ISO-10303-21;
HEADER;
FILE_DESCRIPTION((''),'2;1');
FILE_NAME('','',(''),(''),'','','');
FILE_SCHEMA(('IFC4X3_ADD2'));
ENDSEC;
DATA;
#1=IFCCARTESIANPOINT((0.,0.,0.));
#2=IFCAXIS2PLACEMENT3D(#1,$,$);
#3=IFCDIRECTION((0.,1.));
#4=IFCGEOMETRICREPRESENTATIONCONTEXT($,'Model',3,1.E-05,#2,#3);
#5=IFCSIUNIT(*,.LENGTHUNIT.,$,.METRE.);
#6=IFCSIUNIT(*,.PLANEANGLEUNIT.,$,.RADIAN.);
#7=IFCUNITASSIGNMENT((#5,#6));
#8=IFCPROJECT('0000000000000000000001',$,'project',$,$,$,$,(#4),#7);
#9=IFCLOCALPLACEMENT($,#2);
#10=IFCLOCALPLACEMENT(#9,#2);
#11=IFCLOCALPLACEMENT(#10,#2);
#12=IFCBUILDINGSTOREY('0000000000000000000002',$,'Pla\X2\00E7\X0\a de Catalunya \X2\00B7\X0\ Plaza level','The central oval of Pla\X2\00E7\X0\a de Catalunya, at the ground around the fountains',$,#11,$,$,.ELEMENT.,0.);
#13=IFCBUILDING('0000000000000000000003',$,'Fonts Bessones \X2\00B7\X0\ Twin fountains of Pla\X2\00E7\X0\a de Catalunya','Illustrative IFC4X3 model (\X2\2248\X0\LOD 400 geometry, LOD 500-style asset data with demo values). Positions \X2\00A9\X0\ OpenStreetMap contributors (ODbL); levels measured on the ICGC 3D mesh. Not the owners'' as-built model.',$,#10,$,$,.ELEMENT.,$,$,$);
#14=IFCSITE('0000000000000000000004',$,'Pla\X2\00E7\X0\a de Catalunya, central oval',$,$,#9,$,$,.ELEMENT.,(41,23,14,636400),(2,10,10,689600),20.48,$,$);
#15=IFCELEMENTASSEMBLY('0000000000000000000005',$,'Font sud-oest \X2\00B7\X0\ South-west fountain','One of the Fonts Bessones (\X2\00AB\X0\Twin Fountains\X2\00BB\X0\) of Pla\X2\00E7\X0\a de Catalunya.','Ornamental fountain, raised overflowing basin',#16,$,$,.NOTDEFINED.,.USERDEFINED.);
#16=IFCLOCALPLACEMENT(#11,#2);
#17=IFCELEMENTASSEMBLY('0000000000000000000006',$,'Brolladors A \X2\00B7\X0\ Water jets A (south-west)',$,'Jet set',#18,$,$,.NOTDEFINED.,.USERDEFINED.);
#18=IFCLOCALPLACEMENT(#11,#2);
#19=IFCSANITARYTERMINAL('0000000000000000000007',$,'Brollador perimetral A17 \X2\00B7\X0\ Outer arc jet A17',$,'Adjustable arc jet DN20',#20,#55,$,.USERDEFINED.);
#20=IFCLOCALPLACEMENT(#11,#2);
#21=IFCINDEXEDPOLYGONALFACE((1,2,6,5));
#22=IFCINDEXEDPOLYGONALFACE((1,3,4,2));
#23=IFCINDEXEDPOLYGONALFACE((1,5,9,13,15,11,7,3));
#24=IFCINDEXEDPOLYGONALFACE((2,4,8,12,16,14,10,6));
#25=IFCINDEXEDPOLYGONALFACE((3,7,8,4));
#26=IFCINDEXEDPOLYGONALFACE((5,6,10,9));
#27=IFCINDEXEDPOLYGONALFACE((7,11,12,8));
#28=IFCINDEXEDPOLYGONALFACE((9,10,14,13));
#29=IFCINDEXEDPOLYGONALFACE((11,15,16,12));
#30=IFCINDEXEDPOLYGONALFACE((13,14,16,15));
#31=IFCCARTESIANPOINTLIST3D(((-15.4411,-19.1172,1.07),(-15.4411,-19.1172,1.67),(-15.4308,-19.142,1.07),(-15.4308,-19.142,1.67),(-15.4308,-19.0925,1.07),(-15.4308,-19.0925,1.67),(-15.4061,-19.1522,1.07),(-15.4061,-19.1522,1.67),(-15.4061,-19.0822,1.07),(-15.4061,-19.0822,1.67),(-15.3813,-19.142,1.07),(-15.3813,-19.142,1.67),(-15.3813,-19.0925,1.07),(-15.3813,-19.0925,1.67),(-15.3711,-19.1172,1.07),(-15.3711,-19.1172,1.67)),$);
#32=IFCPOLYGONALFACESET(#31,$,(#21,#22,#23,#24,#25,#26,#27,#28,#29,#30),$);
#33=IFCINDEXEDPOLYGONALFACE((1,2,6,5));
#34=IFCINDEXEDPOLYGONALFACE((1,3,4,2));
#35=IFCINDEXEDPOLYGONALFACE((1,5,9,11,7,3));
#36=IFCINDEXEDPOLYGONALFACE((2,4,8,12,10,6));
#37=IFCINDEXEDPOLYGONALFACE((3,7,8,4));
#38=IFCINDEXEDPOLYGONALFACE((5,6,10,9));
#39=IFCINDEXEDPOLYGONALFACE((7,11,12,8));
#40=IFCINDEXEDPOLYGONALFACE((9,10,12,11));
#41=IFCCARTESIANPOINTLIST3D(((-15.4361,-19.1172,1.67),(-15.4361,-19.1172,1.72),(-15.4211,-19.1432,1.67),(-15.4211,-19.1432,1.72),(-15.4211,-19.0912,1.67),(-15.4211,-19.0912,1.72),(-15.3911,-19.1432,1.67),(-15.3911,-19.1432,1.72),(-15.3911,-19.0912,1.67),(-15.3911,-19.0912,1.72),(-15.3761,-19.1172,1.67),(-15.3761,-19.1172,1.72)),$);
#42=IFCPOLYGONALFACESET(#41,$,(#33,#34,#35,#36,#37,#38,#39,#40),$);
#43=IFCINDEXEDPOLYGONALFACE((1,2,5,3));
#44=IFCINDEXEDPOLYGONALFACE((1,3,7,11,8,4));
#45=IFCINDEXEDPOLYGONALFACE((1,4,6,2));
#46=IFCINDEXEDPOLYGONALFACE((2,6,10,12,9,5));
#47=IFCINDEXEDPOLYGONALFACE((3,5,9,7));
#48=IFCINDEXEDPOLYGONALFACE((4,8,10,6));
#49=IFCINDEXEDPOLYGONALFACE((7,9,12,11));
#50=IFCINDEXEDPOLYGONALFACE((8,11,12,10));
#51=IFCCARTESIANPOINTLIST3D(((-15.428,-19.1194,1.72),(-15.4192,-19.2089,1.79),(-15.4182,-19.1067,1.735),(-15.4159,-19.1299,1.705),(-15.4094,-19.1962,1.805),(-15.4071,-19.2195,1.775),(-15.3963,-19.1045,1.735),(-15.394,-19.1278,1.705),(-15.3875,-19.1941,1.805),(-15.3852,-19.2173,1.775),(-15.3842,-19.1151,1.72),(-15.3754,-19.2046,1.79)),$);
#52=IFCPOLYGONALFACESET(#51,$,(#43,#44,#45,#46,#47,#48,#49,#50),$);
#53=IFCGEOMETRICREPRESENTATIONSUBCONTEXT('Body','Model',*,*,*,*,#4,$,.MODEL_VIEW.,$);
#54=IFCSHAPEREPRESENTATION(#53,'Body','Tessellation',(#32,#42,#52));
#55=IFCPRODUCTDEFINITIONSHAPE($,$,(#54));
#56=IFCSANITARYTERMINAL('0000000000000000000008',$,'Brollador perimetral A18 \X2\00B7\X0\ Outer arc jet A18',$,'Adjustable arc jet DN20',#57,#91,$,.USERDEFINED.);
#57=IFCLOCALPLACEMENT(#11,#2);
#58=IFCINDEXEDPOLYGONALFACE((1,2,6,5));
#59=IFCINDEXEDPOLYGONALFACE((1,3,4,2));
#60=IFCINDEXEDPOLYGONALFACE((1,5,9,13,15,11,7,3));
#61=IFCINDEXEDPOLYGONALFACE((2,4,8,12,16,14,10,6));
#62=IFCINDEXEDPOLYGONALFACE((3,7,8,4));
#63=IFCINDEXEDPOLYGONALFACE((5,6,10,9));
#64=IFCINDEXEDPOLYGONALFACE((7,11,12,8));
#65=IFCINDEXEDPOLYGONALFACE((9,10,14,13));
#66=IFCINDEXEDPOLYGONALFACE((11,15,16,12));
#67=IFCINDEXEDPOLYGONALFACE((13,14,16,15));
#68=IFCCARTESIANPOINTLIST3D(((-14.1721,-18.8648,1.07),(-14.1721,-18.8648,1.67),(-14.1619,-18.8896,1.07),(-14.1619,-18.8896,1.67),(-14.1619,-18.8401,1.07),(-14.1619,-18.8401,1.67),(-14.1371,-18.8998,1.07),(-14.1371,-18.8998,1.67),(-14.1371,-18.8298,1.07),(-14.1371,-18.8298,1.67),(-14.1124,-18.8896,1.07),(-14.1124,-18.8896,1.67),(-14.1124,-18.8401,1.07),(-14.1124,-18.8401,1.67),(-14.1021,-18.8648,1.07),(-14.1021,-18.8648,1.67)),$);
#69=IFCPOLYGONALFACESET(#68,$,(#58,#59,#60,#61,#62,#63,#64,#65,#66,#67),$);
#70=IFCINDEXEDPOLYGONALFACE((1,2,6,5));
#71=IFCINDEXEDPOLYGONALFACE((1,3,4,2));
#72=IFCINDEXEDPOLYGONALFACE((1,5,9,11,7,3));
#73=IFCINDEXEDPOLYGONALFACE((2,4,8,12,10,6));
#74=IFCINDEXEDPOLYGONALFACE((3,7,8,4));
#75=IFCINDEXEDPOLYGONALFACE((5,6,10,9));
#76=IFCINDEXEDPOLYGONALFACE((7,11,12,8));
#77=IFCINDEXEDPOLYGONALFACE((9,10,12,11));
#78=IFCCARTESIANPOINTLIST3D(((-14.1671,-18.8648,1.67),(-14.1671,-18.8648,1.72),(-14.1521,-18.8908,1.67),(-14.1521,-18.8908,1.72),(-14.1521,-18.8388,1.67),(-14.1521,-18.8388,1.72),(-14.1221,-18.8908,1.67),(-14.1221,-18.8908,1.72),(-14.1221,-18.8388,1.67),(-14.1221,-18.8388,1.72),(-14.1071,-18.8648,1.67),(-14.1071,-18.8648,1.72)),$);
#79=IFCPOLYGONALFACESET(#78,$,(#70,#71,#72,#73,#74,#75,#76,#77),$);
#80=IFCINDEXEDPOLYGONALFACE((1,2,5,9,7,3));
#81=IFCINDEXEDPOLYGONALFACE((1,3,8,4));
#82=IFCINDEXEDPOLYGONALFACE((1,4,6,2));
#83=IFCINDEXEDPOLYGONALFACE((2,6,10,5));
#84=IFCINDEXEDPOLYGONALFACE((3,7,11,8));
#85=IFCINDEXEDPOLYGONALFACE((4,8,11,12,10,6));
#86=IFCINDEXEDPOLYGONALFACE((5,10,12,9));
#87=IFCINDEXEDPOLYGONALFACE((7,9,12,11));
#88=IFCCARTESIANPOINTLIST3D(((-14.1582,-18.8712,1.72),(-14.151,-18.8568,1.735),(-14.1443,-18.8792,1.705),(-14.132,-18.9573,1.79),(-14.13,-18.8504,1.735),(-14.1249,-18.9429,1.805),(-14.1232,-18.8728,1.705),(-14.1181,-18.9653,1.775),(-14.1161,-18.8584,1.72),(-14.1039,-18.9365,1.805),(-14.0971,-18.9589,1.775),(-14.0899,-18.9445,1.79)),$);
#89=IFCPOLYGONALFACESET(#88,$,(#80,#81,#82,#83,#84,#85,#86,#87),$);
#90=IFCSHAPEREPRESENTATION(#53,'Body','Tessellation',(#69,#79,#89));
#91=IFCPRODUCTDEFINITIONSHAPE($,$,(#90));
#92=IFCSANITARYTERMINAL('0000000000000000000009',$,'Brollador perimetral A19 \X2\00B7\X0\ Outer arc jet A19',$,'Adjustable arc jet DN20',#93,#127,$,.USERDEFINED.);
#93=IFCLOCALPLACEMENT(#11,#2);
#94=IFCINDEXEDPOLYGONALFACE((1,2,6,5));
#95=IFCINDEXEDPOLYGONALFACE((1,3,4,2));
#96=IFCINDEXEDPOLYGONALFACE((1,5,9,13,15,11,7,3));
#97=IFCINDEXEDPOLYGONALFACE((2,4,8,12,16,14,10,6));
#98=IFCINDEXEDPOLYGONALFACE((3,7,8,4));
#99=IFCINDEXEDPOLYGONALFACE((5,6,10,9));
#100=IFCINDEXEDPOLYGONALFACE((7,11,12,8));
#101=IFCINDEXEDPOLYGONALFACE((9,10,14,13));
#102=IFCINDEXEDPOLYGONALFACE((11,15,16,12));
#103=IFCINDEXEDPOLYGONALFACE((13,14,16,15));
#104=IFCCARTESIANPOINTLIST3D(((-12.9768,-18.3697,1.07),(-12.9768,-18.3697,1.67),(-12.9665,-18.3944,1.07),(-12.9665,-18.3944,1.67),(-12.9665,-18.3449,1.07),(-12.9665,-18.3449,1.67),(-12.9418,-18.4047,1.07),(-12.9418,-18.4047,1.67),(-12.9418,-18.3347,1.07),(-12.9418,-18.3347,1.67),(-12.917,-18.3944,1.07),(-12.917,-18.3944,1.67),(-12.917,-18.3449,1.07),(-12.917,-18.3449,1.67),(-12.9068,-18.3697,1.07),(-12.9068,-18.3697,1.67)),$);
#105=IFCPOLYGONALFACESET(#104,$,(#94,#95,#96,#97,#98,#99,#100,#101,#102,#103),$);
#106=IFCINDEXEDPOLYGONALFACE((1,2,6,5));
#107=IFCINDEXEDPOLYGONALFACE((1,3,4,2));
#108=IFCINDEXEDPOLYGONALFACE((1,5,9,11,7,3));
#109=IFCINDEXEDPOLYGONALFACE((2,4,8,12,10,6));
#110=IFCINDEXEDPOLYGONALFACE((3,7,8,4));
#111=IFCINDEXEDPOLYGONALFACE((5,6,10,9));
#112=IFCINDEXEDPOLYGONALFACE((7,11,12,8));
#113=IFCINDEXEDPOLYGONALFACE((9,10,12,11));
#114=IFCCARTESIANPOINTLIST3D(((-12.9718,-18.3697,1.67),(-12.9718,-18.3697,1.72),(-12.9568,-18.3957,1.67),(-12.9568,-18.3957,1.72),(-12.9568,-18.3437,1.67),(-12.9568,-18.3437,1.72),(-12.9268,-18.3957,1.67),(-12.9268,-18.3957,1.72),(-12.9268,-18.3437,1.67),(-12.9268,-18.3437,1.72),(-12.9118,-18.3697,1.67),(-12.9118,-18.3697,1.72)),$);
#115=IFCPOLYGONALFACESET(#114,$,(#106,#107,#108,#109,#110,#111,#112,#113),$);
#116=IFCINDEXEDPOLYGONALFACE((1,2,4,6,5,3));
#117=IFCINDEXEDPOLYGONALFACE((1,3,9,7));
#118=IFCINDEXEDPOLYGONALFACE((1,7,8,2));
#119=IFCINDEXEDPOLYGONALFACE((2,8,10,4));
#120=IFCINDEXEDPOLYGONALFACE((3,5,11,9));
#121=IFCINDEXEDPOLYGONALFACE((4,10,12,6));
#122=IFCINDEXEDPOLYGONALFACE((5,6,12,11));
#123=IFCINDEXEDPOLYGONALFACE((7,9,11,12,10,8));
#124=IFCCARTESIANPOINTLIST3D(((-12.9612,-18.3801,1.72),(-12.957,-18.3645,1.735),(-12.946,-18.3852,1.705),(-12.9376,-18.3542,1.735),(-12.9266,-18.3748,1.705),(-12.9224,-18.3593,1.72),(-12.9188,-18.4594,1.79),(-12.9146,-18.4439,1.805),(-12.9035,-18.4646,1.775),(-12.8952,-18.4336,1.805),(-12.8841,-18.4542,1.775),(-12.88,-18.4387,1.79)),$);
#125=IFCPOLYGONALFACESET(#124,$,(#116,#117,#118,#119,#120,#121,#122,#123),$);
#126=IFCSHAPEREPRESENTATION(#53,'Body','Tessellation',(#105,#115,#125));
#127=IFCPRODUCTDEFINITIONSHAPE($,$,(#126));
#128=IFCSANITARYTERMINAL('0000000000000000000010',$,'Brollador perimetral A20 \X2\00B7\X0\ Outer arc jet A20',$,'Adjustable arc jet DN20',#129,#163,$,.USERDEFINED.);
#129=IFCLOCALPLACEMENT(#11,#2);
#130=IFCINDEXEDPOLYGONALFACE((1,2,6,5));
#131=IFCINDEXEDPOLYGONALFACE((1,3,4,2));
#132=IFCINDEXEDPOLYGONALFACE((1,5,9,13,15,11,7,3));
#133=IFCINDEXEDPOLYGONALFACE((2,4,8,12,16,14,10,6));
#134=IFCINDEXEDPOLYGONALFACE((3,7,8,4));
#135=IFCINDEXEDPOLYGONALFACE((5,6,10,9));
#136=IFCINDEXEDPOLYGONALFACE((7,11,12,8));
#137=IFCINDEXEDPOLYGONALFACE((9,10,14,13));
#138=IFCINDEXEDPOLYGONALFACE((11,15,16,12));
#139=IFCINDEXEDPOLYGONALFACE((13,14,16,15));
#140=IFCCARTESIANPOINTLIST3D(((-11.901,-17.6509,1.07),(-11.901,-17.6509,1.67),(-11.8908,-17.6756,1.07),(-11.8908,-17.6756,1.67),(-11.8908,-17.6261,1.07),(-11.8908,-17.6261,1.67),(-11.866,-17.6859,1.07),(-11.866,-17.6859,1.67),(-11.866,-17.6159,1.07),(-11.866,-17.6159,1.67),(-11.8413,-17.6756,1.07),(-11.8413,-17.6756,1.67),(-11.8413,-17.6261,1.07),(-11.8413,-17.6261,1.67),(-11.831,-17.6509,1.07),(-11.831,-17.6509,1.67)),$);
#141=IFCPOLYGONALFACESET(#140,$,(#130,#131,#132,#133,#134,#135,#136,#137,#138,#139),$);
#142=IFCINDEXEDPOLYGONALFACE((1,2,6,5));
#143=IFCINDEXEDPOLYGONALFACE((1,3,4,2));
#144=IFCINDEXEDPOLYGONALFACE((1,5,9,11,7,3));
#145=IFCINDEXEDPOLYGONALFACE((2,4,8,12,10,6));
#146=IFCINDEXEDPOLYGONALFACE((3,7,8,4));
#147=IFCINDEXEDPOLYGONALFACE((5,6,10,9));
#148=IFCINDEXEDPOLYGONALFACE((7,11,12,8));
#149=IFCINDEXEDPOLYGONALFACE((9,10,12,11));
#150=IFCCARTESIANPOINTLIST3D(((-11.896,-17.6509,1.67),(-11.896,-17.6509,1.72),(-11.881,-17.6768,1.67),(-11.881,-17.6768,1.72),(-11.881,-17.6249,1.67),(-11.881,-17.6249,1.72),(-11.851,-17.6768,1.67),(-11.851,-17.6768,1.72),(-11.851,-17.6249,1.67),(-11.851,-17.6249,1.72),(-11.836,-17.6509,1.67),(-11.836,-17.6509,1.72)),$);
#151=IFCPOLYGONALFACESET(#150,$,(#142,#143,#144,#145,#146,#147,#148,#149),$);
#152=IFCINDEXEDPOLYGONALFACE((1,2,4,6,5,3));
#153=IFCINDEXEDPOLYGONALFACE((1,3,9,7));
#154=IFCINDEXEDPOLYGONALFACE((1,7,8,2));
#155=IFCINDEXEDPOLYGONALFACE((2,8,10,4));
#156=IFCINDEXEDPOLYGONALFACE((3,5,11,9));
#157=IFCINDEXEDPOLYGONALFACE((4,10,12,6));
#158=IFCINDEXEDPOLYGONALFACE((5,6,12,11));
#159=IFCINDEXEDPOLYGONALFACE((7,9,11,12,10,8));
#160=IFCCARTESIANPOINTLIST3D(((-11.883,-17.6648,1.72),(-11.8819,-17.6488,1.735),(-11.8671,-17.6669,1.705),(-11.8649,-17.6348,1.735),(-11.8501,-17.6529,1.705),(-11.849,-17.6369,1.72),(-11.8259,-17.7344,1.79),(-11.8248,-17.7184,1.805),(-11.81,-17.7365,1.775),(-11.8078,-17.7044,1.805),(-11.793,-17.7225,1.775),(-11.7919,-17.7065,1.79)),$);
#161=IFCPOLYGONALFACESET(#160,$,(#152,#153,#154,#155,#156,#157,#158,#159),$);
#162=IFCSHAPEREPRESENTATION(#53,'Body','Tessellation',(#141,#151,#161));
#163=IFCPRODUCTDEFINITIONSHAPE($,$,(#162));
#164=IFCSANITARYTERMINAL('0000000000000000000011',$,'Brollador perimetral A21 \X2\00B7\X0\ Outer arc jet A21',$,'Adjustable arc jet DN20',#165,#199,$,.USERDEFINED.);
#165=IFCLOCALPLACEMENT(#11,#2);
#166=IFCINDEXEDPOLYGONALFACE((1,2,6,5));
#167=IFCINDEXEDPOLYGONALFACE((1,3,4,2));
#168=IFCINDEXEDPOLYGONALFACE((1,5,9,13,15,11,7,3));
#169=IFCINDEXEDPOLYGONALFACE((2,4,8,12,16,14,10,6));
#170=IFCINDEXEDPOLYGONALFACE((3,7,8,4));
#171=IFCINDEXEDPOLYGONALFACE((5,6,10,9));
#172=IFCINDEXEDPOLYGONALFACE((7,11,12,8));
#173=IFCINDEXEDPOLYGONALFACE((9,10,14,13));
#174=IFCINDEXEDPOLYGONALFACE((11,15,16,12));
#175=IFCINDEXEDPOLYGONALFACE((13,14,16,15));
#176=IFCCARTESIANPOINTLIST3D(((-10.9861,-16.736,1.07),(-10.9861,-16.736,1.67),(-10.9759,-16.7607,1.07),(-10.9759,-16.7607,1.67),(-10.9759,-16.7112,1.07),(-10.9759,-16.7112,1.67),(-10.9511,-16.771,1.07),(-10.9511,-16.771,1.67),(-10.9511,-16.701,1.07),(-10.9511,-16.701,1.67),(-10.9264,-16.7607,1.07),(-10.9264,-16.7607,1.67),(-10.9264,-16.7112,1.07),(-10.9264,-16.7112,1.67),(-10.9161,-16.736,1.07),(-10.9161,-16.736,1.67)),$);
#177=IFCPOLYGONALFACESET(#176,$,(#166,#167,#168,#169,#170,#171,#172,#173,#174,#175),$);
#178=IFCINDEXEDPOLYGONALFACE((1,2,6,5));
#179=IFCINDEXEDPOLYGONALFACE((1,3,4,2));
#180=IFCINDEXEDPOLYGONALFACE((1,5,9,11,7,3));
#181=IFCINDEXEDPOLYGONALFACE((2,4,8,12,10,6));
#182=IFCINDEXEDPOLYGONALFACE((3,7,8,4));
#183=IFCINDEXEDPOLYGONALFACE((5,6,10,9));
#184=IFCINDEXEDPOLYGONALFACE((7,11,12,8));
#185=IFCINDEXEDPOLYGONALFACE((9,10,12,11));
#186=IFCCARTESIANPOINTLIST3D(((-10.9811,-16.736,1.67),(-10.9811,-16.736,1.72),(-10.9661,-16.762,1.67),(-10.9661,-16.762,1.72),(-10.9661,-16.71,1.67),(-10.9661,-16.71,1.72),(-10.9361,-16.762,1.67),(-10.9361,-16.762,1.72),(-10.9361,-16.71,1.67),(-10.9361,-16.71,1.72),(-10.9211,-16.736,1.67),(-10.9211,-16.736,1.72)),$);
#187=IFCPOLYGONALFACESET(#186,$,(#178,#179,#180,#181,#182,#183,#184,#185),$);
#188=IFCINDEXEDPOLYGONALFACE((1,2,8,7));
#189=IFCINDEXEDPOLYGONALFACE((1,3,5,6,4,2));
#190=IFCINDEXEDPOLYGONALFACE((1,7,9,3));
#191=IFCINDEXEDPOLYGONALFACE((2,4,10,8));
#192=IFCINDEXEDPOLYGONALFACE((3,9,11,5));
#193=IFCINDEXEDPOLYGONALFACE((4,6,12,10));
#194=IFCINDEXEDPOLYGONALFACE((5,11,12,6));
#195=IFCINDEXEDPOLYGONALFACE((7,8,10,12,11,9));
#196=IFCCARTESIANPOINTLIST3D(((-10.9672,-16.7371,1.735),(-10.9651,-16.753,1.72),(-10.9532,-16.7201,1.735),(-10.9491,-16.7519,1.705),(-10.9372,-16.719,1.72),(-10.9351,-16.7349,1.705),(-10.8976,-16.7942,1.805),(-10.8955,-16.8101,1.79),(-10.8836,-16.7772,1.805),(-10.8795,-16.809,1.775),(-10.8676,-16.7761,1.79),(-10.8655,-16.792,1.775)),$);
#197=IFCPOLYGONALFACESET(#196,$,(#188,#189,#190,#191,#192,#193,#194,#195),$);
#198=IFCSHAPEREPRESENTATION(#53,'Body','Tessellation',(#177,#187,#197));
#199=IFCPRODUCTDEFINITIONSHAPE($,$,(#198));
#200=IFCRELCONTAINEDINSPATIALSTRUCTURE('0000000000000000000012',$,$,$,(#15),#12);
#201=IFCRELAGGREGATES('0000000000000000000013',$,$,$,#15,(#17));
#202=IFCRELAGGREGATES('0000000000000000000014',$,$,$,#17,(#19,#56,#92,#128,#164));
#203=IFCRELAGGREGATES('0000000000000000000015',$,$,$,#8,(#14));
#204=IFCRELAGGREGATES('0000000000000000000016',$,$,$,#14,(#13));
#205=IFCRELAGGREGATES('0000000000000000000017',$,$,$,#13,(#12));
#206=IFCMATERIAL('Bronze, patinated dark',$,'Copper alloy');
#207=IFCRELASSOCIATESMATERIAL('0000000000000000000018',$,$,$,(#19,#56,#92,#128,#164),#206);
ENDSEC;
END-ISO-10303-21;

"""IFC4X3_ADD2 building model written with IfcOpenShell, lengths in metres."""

from ifc_helpers import new_model, si_unit, direction, frame, origin, place, context, subcontext, project, spatial, polyline, outline, extrude, material, element, aggregate, save


model = new_model("IFC4X3_ADD2")

# Units and contexts
model_context = context("Model", 3, precision=1e-05, world=origin(), true_north=direction((0.0, 1.0)))
body_context = subcontext(model_context, "Body", "Model", "MODEL_VIEW")
ifc_project = project(units=[si_unit("LENGTHUNIT", "METRE"), si_unit("PLANEANGLEUNIT", "RADIAN")], contexts=[model_context])

# Site, building, storey
site_placement = place(None, origin())
site = spatial("IfcSite", under=ifc_project, at=site_placement, Name="Plaça de Catalunya, central oval", CompositionType="ELEMENT", RefLatitude=(41, 23, 14, 636400), RefLongitude=(2, 10, 10, 689600), RefElevation=20.48)
building_placement = place(site_placement, origin())
building = spatial("IfcBuilding", under=site, at=building_placement, Name="Fonts Bessones · Twin fountains of Plaça de Catalunya", Description="Illustrative IFC4X3 model (≈LOD 400 geometry, LOD 500-style asset data with demo values). Positions © OpenStreetMap contributors (ODbL); levels measured on the ICGC 3D mesh. Not the owners' as-built model.", CompositionType="ELEMENT")
storey_placement = place(building_placement, origin())
storey = spatial("IfcBuildingStorey", under=building, at=storey_placement, Name="Plaça de Catalunya · Plaza level", Description="The central oval of Plaça de Catalunya, at the ground around the fountains", CompositionType="ELEMENT", Elevation=0.0)

# Element assemblies, sanitary terminals
assembly_1_placement = place(building_placement, origin())
assembly_1 = element("IfcElementAssembly", 1, at=assembly_1_placement, inside=storey, Name="Font sud-oest · South-west fountain", Description="One of the Fonts Bessones («Twin Fountains») of Plaça de Catalunya.", ObjectType="Ornamental fountain, raised overflowing basin", AssemblyPlace="NOTDEFINED", PredefinedType="USERDEFINED")
assembly_2_placement = place(building_placement, origin())
assembly_2 = element("IfcElementAssembly", 2, at=assembly_2_placement, Name="Brolladors A · Water jets A (south-west)", ObjectType="Jet set", AssemblyPlace="NOTDEFINED", PredefinedType="USERDEFINED")
aggregate(assembly_1, [assembly_2])
ifc_material = material(Name="Bronze, patinated dark", Category="Copper alloy")
sanitary_terminal_1_placement = place(building_placement, origin())
sanitary_terminal_1 = element("IfcSanitaryTerminal", 3, at=sanitary_terminal_1_placement, material=ifc_material, Name="Brollador perimetral A17 · Outer arc jet A17", ObjectType="Adjustable arc jet DN20", PredefinedType="USERDEFINED", context=body_context, shape_type="SweptSolid", body=[
    extrude(outline(polyline([(-15.3711, -19.1172), (-15.3813, -19.0925), (-15.4061, -19.0822), (-15.4308, -19.0925), (-15.4411, -19.1172), (-15.4308, -19.142), (-15.4061, -19.1522), (-15.3813, -19.142), (-15.3711, -19.1172)])), frame((0.0, 0.0, 1.07)), (0.0, 0.0, 1.0), 0.6),
    extrude(outline(polyline([(-15.3761, -19.1172), (-15.3911, -19.0912), (-15.4211, -19.0912), (-15.4361, -19.1172), (-15.4211, -19.1432), (-15.3911, -19.1432), (-15.3761, -19.1172)])), frame((0.0, 0.0, 1.67)), (0.0, 0.0, 1.0), 0.05),
    extrude(outline(polyline([(0.022, 0.0), (0.011, 0.0191), (-0.011, 0.0191), (-0.022, 0.0), (-0.011, -0.0191), (0.011, -0.0191), (0.022, 0.0)])), frame((-15.4061, -19.1172, 1.72), z_axis=(0.07737, -0.785551, 0.613941), x_axis=(-0.995185, -0.098017, 0.0)), (0.0, 0.0, 1.0), 0.114),
])
sanitary_terminal_2_placement = place(building_placement, origin())
sanitary_terminal_2 = element("IfcSanitaryTerminal", 4, at=sanitary_terminal_2_placement, material=ifc_material, Name="Brollador perimetral A18 · Outer arc jet A18", ObjectType="Adjustable arc jet DN20", PredefinedType="USERDEFINED", context=body_context, shape_type="SweptSolid", body=[
    extrude(outline(polyline([(-14.1021, -18.8648), (-14.1124, -18.8401), (-14.1371, -18.8298), (-14.1619, -18.8401), (-14.1721, -18.8648), (-14.1619, -18.8896), (-14.1371, -18.8998), (-14.1124, -18.8896), (-14.1021, -18.8648)])), frame((0.0, 0.0, 1.07)), (0.0, 0.0, 1.0), 0.6),
    extrude(outline(polyline([(-14.1071, -18.8648), (-14.1221, -18.8388), (-14.1521, -18.8388), (-14.1671, -18.8648), (-14.1521, -18.8908), (-14.1221, -18.8908), (-14.1071, -18.8648)])), frame((0.0, 0.0, 1.67)), (0.0, 0.0, 1.0), 0.05),
    extrude(outline(polyline([(0.022, 0.0), (0.011, 0.0191), (-0.011, 0.0191), (-0.022, 0.0), (-0.011, -0.0191), (0.011, -0.0191), (0.022, 0.0)])), frame((-14.1371, -18.8648, 1.72), z_axis=(0.229137, -0.755363, 0.613941), x_axis=(-0.95694, -0.290285, 0.0)), (0.0, 0.0, 1.0), 0.114),
])
sanitary_terminal_3_placement = place(building_placement, origin())
sanitary_terminal_3 = element("IfcSanitaryTerminal", 5, at=sanitary_terminal_3_placement, material=ifc_material, Name="Brollador perimetral A19 · Outer arc jet A19", ObjectType="Adjustable arc jet DN20", PredefinedType="USERDEFINED", context=body_context, shape_type="SweptSolid", body=[
    extrude(outline(polyline([(-12.9068, -18.3697), (-12.917, -18.3449), (-12.9418, -18.3347), (-12.9665, -18.3449), (-12.9768, -18.3697), (-12.9665, -18.3944), (-12.9418, -18.4047), (-12.917, -18.3944), (-12.9068, -18.3697)])), frame((0.0, 0.0, 1.07)), (0.0, 0.0, 1.0), 0.6),
    extrude(outline(polyline([(-12.9118, -18.3697), (-12.9268, -18.3437), (-12.9568, -18.3437), (-12.9718, -18.3697), (-12.9568, -18.3957), (-12.9268, -18.3957), (-12.9118, -18.3697)])), frame((0.0, 0.0, 1.67)), (0.0, 0.0, 1.0), 0.05),
    extrude(outline(polyline([(0.022, 0.0), (0.011, 0.0191), (-0.011, 0.0191), (-0.022, 0.0), (-0.011, -0.0191), (0.011, -0.0191), (0.022, 0.0)])), frame((-12.9418, -18.3697, 1.72), z_axis=(0.372098, -0.696147, 0.613941), x_axis=(-0.881921, -0.471397, 0.0)), (0.0, 0.0, 1.0), 0.114),
])
sanitary_terminal_4_placement = place(building_placement, origin())
sanitary_terminal_4 = element("IfcSanitaryTerminal", 6, at=sanitary_terminal_4_placement, material=ifc_material, Name="Brollador perimetral A20 · Outer arc jet A20", ObjectType="Adjustable arc jet DN20", PredefinedType="USERDEFINED", context=body_context, shape_type="SweptSolid", body=[
    extrude(outline(polyline([(-11.831, -17.6509), (-11.8413, -17.6261), (-11.866, -17.6159), (-11.8908, -17.6261), (-11.901, -17.6509), (-11.8908, -17.6756), (-11.866, -17.6859), (-11.8413, -17.6756), (-11.831, -17.6509)])), frame((0.0, 0.0, 1.07)), (0.0, 0.0, 1.0), 0.6),
    extrude(outline(polyline([(-11.836, -17.6509), (-11.851, -17.6249), (-11.881, -17.6249), (-11.896, -17.6509), (-11.881, -17.6768), (-11.851, -17.6768), (-11.836, -17.6509)])), frame((0.0, 0.0, 1.67)), (0.0, 0.0, 1.0), 0.05),
    extrude(outline(polyline([(0.022, 0.0), (0.011, 0.0191), (-0.011, 0.0191), (-0.022, 0.0), (-0.011, -0.0191), (0.011, -0.0191), (0.022, 0.0)])), frame((-11.866, -17.6509, 1.72), z_axis=(0.50076, -0.610178, 0.613941), x_axis=(-0.77301, -0.634393, 0.0)), (0.0, 0.0, 1.0), 0.114),
])
sanitary_terminal_5_placement = place(building_placement, origin())
sanitary_terminal_5 = element("IfcSanitaryTerminal", 7, at=sanitary_terminal_5_placement, material=ifc_material, Name="Brollador perimetral A21 · Outer arc jet A21", ObjectType="Adjustable arc jet DN20", PredefinedType="USERDEFINED", context=body_context, shape_type="SweptSolid", body=[
    extrude(outline(polyline([(-10.9161, -16.736), (-10.9264, -16.7112), (-10.9511, -16.701), (-10.9759, -16.7112), (-10.9861, -16.736), (-10.9759, -16.7607), (-10.9511, -16.771), (-10.9264, -16.7607), (-10.9161, -16.736)])), frame((0.0, 0.0, 1.07)), (0.0, 0.0, 1.0), 0.6),
    extrude(outline(polyline([(-10.9211, -16.736), (-10.9361, -16.71), (-10.9661, -16.71), (-10.9811, -16.736), (-10.9661, -16.762), (-10.9361, -16.762), (-10.9211, -16.736)])), frame((0.0, 0.0, 1.67)), (0.0, 0.0, 1.0), 0.05),
    extrude(outline(polyline([(0.022, 0.0), (0.011, 0.0191), (-0.011, 0.0191), (-0.022, 0.0), (-0.011, -0.0191), (0.011, -0.0191), (0.022, 0.0)])), frame((-10.9511, -16.736, 1.72), z_axis=(0.610178, -0.50076, 0.613941), x_axis=(-0.634393, -0.77301, 0.0)), (0.0, 0.0, 1.0), 0.114),
])
aggregate(assembly_2, [sanitary_terminal_1, sanitary_terminal_2, sanitary_terminal_3, sanitary_terminal_4, sanitary_terminal_5])

save(model, "model.ifc")
